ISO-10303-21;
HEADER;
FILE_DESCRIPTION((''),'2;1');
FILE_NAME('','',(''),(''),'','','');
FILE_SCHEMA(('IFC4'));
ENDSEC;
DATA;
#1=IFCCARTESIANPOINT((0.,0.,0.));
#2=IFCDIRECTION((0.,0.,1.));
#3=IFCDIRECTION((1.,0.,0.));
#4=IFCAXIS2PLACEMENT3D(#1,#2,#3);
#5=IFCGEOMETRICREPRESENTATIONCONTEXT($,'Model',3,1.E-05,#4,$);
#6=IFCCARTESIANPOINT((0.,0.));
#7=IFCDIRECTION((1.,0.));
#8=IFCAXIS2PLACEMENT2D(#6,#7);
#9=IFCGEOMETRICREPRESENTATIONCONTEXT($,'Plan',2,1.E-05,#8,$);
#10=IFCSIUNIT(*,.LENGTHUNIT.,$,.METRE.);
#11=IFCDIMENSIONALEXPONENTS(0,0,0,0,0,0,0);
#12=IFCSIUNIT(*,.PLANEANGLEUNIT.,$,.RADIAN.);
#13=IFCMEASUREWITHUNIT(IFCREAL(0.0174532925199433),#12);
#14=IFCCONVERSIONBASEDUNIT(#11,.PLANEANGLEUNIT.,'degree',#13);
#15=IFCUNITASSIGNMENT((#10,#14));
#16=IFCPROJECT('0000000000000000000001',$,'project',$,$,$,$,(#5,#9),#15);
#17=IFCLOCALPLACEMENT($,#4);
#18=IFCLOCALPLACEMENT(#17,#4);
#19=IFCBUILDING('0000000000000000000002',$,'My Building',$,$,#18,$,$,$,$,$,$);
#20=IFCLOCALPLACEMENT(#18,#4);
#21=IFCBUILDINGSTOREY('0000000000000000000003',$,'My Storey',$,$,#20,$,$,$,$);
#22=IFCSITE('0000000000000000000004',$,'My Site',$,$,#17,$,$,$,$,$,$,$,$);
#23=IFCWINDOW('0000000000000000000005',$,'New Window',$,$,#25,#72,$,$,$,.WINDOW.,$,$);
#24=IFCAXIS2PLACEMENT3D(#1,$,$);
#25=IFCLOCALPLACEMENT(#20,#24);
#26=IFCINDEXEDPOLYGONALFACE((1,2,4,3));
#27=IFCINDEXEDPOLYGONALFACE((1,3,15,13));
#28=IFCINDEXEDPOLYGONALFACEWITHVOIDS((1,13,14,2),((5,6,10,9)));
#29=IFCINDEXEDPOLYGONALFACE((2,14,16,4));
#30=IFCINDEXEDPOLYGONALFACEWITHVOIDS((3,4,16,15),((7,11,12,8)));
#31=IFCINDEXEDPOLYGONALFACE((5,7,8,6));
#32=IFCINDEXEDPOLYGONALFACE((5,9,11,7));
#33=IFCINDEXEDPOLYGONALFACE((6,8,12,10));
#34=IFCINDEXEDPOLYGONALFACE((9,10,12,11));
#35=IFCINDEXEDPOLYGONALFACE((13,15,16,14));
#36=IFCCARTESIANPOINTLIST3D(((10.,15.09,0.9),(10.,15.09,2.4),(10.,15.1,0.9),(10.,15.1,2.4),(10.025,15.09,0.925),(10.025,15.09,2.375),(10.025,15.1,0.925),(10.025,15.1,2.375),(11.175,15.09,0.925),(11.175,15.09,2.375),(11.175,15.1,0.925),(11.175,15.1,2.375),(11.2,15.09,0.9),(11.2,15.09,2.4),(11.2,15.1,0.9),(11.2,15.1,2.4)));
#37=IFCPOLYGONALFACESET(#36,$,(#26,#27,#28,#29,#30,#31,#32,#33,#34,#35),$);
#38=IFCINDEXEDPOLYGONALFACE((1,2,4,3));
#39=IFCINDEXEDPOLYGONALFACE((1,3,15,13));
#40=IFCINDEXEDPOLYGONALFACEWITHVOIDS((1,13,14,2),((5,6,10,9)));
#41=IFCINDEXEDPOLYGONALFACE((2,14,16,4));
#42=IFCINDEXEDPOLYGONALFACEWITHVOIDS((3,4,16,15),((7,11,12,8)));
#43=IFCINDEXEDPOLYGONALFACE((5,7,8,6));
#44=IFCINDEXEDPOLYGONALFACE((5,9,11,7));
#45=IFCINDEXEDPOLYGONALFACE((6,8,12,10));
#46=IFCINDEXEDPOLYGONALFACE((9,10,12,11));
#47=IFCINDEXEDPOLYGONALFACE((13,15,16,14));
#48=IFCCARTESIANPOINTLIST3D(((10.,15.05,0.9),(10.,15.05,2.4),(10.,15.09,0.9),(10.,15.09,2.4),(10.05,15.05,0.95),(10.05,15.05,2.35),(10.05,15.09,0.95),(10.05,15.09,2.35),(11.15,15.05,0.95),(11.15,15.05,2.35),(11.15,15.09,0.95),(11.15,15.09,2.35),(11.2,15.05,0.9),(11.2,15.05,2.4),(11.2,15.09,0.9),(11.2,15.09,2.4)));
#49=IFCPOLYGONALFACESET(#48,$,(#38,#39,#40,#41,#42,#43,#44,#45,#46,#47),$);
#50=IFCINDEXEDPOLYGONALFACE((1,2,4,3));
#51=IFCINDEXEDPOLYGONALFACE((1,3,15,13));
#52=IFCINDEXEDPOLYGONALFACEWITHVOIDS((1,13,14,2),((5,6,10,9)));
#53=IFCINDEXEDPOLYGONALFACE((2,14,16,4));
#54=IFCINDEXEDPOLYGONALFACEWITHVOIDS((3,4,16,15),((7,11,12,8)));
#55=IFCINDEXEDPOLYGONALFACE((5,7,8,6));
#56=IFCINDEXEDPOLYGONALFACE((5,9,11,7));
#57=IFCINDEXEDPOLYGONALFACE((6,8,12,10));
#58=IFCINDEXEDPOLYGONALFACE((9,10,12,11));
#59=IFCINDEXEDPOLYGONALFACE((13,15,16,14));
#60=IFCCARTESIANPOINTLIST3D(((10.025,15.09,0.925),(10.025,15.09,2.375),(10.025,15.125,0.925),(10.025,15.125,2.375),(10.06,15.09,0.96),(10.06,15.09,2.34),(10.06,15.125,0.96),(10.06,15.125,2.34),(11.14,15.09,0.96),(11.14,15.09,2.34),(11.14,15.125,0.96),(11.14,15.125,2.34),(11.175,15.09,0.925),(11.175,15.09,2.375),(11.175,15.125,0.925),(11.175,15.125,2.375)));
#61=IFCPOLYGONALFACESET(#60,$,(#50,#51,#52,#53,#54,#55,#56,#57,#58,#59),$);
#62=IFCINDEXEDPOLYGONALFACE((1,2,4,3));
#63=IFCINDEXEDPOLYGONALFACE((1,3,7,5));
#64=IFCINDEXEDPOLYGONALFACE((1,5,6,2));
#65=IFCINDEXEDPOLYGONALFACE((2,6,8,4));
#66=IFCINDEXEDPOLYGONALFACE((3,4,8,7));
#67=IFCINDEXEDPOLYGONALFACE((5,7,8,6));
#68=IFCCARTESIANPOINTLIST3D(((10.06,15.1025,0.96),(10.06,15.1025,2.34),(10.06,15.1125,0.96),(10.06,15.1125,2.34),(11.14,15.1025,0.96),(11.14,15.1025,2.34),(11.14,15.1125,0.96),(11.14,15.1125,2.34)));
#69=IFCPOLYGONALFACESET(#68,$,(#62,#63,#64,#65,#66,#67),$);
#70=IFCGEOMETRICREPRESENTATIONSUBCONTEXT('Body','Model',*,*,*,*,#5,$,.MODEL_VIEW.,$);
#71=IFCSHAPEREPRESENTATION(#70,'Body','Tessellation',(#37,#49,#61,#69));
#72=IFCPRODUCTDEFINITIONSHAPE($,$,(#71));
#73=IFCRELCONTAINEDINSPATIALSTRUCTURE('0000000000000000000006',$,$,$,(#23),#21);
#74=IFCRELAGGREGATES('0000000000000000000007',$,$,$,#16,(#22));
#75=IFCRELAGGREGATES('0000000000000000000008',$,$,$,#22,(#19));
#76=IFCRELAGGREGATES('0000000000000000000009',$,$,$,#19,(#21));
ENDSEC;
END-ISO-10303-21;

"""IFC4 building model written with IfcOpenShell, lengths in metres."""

from ifc_helpers import new_model, entity, si_unit, converted_unit, frame, origin_with_axes, origin_2d_with_axis, place, context, subcontext, project, spatial, line, indexed_curve, outline, extrude, element, save


model = new_model("IFC4")

# Units and contexts
model_context = context("Model", 3, precision=1e-05, world=origin_with_axes())
plan_context = context("Plan", 2, precision=1e-05, world=origin_2d_with_axis())
body_context = subcontext(model_context, "Body", "Model", "MODEL_VIEW")
ifc_project = project(units=[si_unit("LENGTHUNIT", "METRE"), converted_unit("PLANEANGLEUNIT", "degree", entity("IfcReal", 0.0174532925199433), si_unit("PLANEANGLEUNIT", "RADIAN"), dimensions=[0, 0, 0, 0, 0, 0, 0])], contexts=[model_context, plan_context])

# Site, building, storey
site_placement = place(None, origin_with_axes())
site = spatial("IfcSite", under=ifc_project, at=site_placement, Name="My Site")
building_placement = place(site_placement, origin_with_axes())
building = spatial("IfcBuilding", under=site, at=building_placement, Name="My Building")
storey_placement = place(building_placement, origin_with_axes())
storey = spatial("IfcBuildingStorey", under=building, at=storey_placement, Name="My Storey")

# Window
for number, where, z_axis, x_axis, name in (
    (1, (10.0, 15.0, 0.9), (0.0, 0.0, 1.0), (1.0, 0.0, 0.0), "New Window"),
):
    element("IfcWindow", number, at=place(storey_placement, frame(where, z_axis=z_axis, x_axis=x_axis)), inside=storey, Name=name, PredefinedType="WINDOW", context=body_context, shape_type="SweptSolid", body=[
        extrude(outline(indexed_curve([(0.0, 0.0), (1.2, 0.0), (1.2, 1.5), (0.0, 1.5)], segments=[line(1, 2, 3, 4, 1)]), holes=[indexed_curve([(0.025, 0.025), (1.175, 0.025), (1.175, 1.475), (0.025, 1.475)], segments=[line(1, 2, 3, 4, 1)])]), frame((0.0, 0.09, 0.0), z_axis=(0.0, -1.0, 0.0), x_axis=(1.0, 0.0, 0.0)), (0.0, 0.0, -1.0), 0.01),
        extrude(outline(indexed_curve([(0.0, 0.0), (1.2, 0.0), (1.2, 1.5), (0.0, 1.5)], segments=[line(1, 2, 3, 4, 1)]), holes=[indexed_curve([(0.05, 0.05), (1.15, 0.05), (1.15, 1.45), (0.05, 1.45)], segments=[line(1, 2, 3, 4, 1)])]), frame((0.0, 0.05, 0.0), z_axis=(0.0, -1.0, 0.0), x_axis=(1.0, 0.0, 0.0)), (0.0, 0.0, -1.0), 0.04),
        extrude(outline(indexed_curve([(0.0, 0.0), (1.15, 0.0), (1.15, 1.45), (0.0, 1.45)], segments=[line(1, 2, 3, 4, 1)]), holes=[indexed_curve([(0.035, 0.035), (1.115, 0.035), (1.115, 1.415), (0.035, 1.415)], segments=[line(1, 2, 3, 4, 1)])]), frame((0.025, 0.09, 0.025), z_axis=(0.0, -1.0, 0.0), x_axis=(1.0, 0.0, 0.0)), (0.0, 0.0, -1.0), 0.035),
        extrude(outline(indexed_curve([(0.035, 0.035), (1.115, 0.035), (1.115, 1.415), (0.035, 1.415)], segments=[line(1, 2, 3, 4, 1)])), frame((0.025, 0.1025, 0.025), z_axis=(0.0, -1.0, 0.0), x_axis=(1.0, 0.0, 0.0)), (0.0, 0.0, -1.0), 0.01),
    ])

save(model, "model.ifc")
